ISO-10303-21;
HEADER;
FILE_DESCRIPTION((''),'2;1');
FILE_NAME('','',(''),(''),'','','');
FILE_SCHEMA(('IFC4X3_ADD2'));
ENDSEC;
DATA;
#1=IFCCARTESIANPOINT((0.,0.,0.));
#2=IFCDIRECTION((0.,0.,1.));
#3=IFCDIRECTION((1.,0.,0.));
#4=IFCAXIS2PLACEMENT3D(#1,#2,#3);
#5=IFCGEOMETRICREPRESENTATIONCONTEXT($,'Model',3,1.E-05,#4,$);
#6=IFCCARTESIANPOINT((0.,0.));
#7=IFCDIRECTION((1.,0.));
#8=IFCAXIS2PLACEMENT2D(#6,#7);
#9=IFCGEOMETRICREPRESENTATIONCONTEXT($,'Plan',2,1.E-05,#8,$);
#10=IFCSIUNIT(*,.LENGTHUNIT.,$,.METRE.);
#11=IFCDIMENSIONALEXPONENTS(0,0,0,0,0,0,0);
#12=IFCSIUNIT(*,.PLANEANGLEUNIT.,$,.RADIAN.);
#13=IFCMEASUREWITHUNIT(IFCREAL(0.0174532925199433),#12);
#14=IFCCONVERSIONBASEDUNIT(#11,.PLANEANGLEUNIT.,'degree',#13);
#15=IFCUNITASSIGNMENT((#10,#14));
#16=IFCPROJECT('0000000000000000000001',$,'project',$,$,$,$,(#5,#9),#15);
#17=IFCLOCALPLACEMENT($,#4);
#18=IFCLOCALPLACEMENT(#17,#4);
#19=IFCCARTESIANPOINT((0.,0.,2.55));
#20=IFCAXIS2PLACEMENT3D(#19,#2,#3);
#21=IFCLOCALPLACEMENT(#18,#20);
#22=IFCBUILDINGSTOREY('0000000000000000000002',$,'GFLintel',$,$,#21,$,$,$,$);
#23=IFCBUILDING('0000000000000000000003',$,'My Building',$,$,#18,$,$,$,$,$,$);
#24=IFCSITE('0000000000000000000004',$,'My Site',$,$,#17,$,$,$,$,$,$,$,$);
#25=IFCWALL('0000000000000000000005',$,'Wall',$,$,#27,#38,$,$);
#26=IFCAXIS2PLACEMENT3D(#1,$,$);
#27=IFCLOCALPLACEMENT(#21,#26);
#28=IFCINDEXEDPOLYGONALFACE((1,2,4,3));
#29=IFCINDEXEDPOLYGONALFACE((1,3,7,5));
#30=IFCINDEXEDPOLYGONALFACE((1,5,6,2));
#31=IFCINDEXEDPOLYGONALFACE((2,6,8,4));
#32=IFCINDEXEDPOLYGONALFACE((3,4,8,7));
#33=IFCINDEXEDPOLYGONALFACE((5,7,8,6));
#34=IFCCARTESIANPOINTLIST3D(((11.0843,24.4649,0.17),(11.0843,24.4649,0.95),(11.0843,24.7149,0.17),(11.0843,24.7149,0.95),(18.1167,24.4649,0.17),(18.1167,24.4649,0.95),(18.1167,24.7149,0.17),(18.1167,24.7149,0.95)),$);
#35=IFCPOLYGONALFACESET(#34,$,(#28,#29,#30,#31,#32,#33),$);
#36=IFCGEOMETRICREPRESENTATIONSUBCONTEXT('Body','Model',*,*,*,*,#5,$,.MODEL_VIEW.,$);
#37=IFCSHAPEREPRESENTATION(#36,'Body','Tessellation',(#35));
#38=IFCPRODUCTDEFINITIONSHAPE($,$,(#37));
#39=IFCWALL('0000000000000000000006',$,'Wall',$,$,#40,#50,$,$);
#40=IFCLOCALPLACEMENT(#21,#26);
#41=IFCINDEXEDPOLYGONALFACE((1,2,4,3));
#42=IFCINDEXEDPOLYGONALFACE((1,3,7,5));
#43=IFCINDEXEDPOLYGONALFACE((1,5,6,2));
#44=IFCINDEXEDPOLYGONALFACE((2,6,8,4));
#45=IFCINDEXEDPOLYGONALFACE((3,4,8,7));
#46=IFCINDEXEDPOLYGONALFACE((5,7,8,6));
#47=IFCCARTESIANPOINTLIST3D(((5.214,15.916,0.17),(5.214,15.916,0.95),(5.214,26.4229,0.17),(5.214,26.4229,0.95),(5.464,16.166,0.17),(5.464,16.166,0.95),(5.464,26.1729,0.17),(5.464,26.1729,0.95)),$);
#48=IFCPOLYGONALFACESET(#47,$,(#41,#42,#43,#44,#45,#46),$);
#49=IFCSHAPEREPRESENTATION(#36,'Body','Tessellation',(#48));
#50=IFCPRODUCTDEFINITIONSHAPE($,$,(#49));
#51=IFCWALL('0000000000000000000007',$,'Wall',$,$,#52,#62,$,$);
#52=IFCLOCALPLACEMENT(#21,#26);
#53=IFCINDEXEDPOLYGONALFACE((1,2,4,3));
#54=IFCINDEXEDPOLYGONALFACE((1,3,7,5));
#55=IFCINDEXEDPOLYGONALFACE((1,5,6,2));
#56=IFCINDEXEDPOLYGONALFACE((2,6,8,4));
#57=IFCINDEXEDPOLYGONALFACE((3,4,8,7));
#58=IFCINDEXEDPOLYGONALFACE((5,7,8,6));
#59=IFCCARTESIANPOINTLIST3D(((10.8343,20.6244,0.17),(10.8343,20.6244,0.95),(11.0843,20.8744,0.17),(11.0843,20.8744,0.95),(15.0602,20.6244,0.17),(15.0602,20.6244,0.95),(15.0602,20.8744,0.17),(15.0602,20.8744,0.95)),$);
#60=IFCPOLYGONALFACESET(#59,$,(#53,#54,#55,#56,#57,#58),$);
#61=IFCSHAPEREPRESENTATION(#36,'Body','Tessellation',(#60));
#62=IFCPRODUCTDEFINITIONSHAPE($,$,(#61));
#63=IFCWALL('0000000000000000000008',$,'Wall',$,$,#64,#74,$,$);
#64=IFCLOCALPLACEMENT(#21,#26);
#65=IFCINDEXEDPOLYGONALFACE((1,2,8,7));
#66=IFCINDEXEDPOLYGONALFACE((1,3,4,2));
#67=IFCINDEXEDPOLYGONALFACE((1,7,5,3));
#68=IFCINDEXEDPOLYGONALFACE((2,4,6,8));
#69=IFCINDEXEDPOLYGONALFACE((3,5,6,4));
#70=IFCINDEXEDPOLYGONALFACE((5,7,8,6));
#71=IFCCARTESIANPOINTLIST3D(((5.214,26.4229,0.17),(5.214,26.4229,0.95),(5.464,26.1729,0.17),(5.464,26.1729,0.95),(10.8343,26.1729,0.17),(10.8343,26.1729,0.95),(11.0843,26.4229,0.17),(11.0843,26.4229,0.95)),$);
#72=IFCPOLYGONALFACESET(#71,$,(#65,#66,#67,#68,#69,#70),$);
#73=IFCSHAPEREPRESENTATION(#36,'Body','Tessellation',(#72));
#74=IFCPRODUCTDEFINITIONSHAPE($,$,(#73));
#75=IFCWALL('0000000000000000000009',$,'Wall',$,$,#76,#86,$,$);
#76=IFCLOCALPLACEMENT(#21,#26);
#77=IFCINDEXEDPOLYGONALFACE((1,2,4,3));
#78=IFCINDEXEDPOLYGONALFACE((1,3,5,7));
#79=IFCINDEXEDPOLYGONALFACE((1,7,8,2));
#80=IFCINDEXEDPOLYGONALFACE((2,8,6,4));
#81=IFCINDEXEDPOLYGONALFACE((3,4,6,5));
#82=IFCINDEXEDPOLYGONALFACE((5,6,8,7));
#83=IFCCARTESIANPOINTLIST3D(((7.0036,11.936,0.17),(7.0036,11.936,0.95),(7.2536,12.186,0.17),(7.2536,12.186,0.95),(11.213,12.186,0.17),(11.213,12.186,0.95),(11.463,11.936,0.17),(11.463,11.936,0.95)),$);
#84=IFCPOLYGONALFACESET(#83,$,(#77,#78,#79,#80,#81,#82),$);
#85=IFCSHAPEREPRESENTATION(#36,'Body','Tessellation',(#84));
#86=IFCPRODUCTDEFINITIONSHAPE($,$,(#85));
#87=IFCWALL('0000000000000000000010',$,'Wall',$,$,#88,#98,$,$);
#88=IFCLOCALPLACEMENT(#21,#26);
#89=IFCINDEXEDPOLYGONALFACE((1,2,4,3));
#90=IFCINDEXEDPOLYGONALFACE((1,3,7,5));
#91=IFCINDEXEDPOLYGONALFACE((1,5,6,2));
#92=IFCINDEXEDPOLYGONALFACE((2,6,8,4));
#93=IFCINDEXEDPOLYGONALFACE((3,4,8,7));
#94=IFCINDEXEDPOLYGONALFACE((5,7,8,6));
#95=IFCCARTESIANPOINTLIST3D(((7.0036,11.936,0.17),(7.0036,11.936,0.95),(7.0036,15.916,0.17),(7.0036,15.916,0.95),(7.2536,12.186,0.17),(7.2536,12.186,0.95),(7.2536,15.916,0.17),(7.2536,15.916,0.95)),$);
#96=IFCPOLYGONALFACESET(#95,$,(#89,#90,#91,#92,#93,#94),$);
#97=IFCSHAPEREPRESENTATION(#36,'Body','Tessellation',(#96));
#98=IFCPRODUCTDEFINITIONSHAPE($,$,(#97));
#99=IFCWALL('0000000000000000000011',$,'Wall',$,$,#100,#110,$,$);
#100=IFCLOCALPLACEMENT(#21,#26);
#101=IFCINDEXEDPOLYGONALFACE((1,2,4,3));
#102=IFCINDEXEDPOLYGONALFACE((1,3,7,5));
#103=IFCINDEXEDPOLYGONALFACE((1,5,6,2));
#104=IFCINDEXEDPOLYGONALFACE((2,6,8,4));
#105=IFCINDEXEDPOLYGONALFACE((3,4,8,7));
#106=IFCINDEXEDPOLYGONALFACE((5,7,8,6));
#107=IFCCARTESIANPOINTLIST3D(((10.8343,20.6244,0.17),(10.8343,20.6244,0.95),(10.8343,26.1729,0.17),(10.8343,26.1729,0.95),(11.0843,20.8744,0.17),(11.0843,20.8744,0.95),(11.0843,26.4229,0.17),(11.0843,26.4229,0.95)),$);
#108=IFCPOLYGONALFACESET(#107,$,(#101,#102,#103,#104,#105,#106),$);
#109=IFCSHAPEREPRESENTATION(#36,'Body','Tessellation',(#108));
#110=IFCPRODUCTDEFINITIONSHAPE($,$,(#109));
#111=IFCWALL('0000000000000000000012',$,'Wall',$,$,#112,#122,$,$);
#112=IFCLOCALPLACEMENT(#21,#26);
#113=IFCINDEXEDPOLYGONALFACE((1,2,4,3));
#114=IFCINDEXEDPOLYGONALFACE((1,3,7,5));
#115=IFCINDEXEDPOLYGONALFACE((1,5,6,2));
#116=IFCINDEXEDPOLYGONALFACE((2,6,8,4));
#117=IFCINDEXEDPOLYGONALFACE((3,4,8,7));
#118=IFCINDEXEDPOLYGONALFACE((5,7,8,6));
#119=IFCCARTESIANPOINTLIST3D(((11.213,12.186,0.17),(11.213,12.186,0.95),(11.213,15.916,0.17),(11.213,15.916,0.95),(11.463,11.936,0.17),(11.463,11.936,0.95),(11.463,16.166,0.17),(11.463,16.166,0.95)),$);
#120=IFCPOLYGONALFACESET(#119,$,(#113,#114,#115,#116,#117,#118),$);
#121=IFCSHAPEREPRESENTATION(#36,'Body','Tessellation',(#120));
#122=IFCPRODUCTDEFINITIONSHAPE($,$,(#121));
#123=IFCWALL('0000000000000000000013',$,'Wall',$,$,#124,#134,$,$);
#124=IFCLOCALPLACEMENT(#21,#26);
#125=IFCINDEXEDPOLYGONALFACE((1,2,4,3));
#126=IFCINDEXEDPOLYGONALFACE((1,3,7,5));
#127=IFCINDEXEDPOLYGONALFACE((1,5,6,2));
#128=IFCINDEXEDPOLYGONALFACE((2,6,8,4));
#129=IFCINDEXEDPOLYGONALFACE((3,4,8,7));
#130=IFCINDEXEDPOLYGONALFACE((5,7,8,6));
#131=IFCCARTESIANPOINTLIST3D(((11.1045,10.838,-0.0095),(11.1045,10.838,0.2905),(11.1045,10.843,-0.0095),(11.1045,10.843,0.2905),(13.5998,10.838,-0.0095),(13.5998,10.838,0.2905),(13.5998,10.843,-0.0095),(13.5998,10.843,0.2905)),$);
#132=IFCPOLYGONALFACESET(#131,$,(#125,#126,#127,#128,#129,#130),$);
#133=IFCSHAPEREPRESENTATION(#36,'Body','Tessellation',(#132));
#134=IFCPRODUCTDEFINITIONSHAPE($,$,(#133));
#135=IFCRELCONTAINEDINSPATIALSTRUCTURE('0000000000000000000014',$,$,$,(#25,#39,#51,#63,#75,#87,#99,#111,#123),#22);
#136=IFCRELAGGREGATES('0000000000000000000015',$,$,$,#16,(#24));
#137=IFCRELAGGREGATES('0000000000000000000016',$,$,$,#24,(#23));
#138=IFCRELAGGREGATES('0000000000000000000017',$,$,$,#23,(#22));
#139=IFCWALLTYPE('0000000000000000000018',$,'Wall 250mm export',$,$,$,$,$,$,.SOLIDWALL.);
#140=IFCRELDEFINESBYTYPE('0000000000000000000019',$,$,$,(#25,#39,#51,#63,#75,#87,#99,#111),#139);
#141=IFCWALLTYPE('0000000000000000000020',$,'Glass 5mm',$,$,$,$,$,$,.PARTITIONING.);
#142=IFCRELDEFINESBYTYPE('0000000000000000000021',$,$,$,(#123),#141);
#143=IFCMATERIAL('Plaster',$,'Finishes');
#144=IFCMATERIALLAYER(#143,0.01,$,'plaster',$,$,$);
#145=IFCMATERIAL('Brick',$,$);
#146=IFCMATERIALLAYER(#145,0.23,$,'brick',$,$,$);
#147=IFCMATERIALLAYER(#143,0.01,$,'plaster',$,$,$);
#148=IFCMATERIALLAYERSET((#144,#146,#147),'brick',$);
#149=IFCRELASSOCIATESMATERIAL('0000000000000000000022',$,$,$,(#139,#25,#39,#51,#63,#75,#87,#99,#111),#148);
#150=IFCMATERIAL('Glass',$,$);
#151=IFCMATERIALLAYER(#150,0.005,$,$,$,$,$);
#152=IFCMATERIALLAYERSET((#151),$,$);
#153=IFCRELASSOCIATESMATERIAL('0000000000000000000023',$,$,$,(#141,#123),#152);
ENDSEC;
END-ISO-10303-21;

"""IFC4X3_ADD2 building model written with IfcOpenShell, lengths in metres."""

from ifc_helpers import new_model, entity, si_unit, converted_unit, frame, origin_with_axes, origin_2d_with_axis, place, context, subcontext, project, spatial, line, indexed_curve, outline, extrude, material, layer, layer_set, layer_usage, type_object, element, save


model = new_model("IFC4X3_ADD2")

# Units and contexts
model_context = context("Model", 3, precision=1e-05, world=origin_with_axes())
plan_context = context("Plan", 2, precision=1e-05, world=origin_2d_with_axis())
body_context = subcontext(model_context, "Body", "Model", "MODEL_VIEW")
ifc_project = project(units=[si_unit("LENGTHUNIT", "METRE"), converted_unit("PLANEANGLEUNIT", "degree", entity("IfcReal", 0.0174532925199433), si_unit("PLANEANGLEUNIT", "RADIAN"), dimensions=[0, 0, 0, 0, 0, 0, 0])], contexts=[model_context, plan_context])

# Site, building, storey
site_placement = place(None, origin_with_axes())
site = spatial("IfcSite", under=ifc_project, at=site_placement, Name="My Site")
building_placement = place(site_placement, origin_with_axes())
building = spatial("IfcBuilding", under=site, at=building_placement, Name="My Building")
storey_placement = place(building_placement, frame((0.0, 0.0, 2.55), z_axis=(0.0, 0.0, 1.0), x_axis=(1.0, 0.0, 0.0)))
storey = spatial("IfcBuildingStorey", under=building, at=storey_placement, Name="GFLintel")

# Shared definitions
ifc_material_1 = material(Name="Glass")

# Walls
ifc_material_2 = material(Name="Plaster", Category="Finishes")
ifc_layer_1 = layer(ifc_material_2, 0.01, Name="plaster")
ifc_material_3 = material(Name="Brick")
ifc_layer_2 = layer(ifc_material_3, 0.23, Name="brick")
ifc_layer_3 = layer(ifc_material_2, 0.01, Name="plaster")
ifc_layer_set_1 = layer_set([ifc_layer_1, ifc_layer_2, ifc_layer_3], Name="brick")
wall_type_1 = type_object("IfcWallType", Name="Wall 250mm export", PredefinedType="SOLIDWALL", material=ifc_layer_set_1)
ifc_layer_usage_1 = layer_usage(ifc_layer_set_1, "AXIS2", "POSITIVE", 0.0)
wall_1_placement = place(storey_placement, frame((11.0843, 24.4649, 0.17), z_axis=(0.0, 0.0, 1.0), x_axis=(1.0, 0.0, 0.0)))
element("IfcWall", 1, at=wall_1_placement, inside=storey, type_object=wall_type_1, material=ifc_layer_usage_1, Name="Wall", context=body_context, shape_type="SweptSolid", body=[
    extrude(outline(indexed_curve([(0.0, 0.0), (0.0, 0.25), (7.0324, 0.25), (7.0324, 0.0)], segments=[line(1, 2, 3, 4, 1)])), origin_with_axes(), (0.0, 0.0, 1.0), 0.78),
])
ifc_layer_usage_2 = layer_usage(ifc_layer_set_1, "AXIS2", "POSITIVE", 0.0)
wall_2_placement = place(storey_placement, frame((5.464, 15.916, 0.17), z_axis=(0.0, 0.0, 1.0), x_axis=(0.0, 1.0, 0.0)))
element("IfcWall", 2, at=wall_2_placement, inside=storey, type_object=wall_type_1, material=ifc_layer_usage_2, Name="Wall", context=body_context, shape_type="SweptSolid", body=[
    extrude(outline(indexed_curve([(0.25, 0.0), (0.0, 0.25), (10.5069, 0.25), (10.2569, 0.0)], segments=[line(1, 2, 3, 4, 1)])), origin_with_axes(), (0.0, 0.0, 1.0), 0.78),
])
ifc_layer_usage_3 = layer_usage(ifc_layer_set_1, "AXIS2", "POSITIVE", 0.0)
wall_3_placement = place(storey_placement, frame((11.0843, 20.6244, 0.17), z_axis=(0.0, 0.0, 1.0), x_axis=(1.0, 0.0, 0.0)))
element("IfcWall", 3, at=wall_3_placement, inside=storey, type_object=wall_type_1, material=ifc_layer_usage_3, Name="Wall", context=body_context, shape_type="SweptSolid", body=[
    extrude(outline(indexed_curve([(-0.25, 0.0), (0.0, 0.25), (3.9759, 0.25), (3.9759, 0.0)], segments=[line(1, 2, 3, 4, 1)])), origin_with_axes(), (0.0, 0.0, 1.0), 0.78),
])
ifc_layer_usage_4 = layer_usage(ifc_layer_set_1, "AXIS2", "POSITIVE", 0.0)
wall_4_placement = place(storey_placement, frame((5.464, 26.1729, 0.17), z_axis=(0.0, 0.0, 1.0), x_axis=(1.0, 0.0, 0.0)))
element("IfcWall", 4, at=wall_4_placement, inside=storey, type_object=wall_type_1, material=ifc_layer_usage_4, Name="Wall", context=body_context, shape_type="SweptSolid", body=[
    extrude(outline(indexed_curve([(0.0, 0.0), (-0.25, 0.25), (5.6203, 0.25), (5.3703, 0.0)], segments=[line(1, 2, 3, 4, 1)])), origin_with_axes(), (0.0, 0.0, 1.0), 0.78),
])
ifc_layer_usage_5 = layer_usage(ifc_layer_set_1, "AXIS2", "POSITIVE", 0.0)
wall_5_placement = place(storey_placement, frame((7.2536, 11.936, 0.17), z_axis=(0.0, 0.0, 1.0), x_axis=(1.0, 0.0, 0.0)))
element("IfcWall", 5, at=wall_5_placement, inside=storey, type_object=wall_type_1, material=ifc_layer_usage_5, Name="Wall", context=body_context, shape_type="SweptSolid", body=[
    extrude(outline(indexed_curve([(-0.25, 0.0), (0.0, 0.25), (3.9594, 0.25), (4.2094, 0.0)], segments=[line(1, 2, 3, 4, 1)])), origin_with_axes(), (0.0, 0.0, 1.0), 0.78),
])
ifc_layer_usage_6 = layer_usage(ifc_layer_set_1, "AXIS2", "POSITIVE", 0.0)
wall_6_placement = place(storey_placement, frame((7.2536, 11.936, 0.17), z_axis=(0.0, 0.0, 1.0), x_axis=(0.0, 1.0, 0.0)))
element("IfcWall", 6, at=wall_6_placement, inside=storey, type_object=wall_type_1, material=ifc_layer_usage_6, Name="Wall", context=body_context, shape_type="SweptSolid", body=[
    extrude(outline(indexed_curve([(0.25, 0.0), (0.0, 0.25), (3.98, 0.25), (3.98, 0.0)], segments=[line(1, 2, 3, 4, 1)])), origin_with_axes(), (0.0, 0.0, 1.0), 0.78),
])
ifc_layer_usage_7 = layer_usage(ifc_layer_set_1, "AXIS2", "POSITIVE", 0.0)
wall_7_placement = place(storey_placement, frame((11.0843, 20.6244, 0.17), z_axis=(0.0, 0.0, 1.0), x_axis=(0.0, 1.0, 0.0)))
element("IfcWall", 7, at=wall_7_placement, inside=storey, type_object=wall_type_1, material=ifc_layer_usage_7, Name="Wall", context=body_context, shape_type="SweptSolid", body=[
    extrude(outline(indexed_curve([(0.25, 0.0), (0.0, 0.25), (5.5485, 0.25), (5.7985, 0.0)], segments=[line(1, 2, 3, 4, 1)])), origin_with_axes(), (0.0, 0.0, 1.0), 0.78),
])
ifc_layer_usage_8 = layer_usage(ifc_layer_set_1, "AXIS2", "POSITIVE", 0.0)
wall_8_placement = place(storey_placement, frame((11.463, 11.936, 0.17), z_axis=(0.0, 0.0, 1.0), x_axis=(0.0, 1.0, 0.0)))
element("IfcWall", 8, at=wall_8_placement, inside=storey, type_object=wall_type_1, material=ifc_layer_usage_8, Name="Wall", context=body_context, shape_type="SweptSolid", body=[
    extrude(outline(indexed_curve([(0.0, 0.0), (0.25, 0.25), (3.98, 0.25), (4.23, 0.0)], segments=[line(1, 2, 3, 4, 1)])), origin_with_axes(), (0.0, 0.0, 1.0), 0.78),
])
ifc_layer_4 = layer(ifc_material_1, 0.005)
ifc_layer_set_2 = layer_set([ifc_layer_4])
ifc_layer_usage_9 = layer_usage(ifc_layer_set_2, "AXIS2", "POSITIVE", 0.0)
wall_type_2 = type_object("IfcWallType", Name="Glass 5mm", PredefinedType="PARTITIONING", material=ifc_layer_set_2)
wall_9_placement = place(storey_placement, frame((11.1045, 10.838, -0.0095), z_axis=(0.0, 0.0, 1.0), x_axis=(1.0, 0.0, 0.0)))
element("IfcWall", 9, at=wall_9_placement, inside=storey, type_object=wall_type_2, material=ifc_layer_usage_9, Name="Wall", context=body_context, shape_type="SweptSolid", body=[
    extrude(outline(indexed_curve([(0.0, 0.0), (0.0, 0.005), (2.4954, 0.005), (2.4954, 0.0)], segments=[line(1, 2, 3, 4, 1)])), origin_with_axes(), (0.0, 0.0, 1.0), 0.3),
])

save(model, "model.ifc")
